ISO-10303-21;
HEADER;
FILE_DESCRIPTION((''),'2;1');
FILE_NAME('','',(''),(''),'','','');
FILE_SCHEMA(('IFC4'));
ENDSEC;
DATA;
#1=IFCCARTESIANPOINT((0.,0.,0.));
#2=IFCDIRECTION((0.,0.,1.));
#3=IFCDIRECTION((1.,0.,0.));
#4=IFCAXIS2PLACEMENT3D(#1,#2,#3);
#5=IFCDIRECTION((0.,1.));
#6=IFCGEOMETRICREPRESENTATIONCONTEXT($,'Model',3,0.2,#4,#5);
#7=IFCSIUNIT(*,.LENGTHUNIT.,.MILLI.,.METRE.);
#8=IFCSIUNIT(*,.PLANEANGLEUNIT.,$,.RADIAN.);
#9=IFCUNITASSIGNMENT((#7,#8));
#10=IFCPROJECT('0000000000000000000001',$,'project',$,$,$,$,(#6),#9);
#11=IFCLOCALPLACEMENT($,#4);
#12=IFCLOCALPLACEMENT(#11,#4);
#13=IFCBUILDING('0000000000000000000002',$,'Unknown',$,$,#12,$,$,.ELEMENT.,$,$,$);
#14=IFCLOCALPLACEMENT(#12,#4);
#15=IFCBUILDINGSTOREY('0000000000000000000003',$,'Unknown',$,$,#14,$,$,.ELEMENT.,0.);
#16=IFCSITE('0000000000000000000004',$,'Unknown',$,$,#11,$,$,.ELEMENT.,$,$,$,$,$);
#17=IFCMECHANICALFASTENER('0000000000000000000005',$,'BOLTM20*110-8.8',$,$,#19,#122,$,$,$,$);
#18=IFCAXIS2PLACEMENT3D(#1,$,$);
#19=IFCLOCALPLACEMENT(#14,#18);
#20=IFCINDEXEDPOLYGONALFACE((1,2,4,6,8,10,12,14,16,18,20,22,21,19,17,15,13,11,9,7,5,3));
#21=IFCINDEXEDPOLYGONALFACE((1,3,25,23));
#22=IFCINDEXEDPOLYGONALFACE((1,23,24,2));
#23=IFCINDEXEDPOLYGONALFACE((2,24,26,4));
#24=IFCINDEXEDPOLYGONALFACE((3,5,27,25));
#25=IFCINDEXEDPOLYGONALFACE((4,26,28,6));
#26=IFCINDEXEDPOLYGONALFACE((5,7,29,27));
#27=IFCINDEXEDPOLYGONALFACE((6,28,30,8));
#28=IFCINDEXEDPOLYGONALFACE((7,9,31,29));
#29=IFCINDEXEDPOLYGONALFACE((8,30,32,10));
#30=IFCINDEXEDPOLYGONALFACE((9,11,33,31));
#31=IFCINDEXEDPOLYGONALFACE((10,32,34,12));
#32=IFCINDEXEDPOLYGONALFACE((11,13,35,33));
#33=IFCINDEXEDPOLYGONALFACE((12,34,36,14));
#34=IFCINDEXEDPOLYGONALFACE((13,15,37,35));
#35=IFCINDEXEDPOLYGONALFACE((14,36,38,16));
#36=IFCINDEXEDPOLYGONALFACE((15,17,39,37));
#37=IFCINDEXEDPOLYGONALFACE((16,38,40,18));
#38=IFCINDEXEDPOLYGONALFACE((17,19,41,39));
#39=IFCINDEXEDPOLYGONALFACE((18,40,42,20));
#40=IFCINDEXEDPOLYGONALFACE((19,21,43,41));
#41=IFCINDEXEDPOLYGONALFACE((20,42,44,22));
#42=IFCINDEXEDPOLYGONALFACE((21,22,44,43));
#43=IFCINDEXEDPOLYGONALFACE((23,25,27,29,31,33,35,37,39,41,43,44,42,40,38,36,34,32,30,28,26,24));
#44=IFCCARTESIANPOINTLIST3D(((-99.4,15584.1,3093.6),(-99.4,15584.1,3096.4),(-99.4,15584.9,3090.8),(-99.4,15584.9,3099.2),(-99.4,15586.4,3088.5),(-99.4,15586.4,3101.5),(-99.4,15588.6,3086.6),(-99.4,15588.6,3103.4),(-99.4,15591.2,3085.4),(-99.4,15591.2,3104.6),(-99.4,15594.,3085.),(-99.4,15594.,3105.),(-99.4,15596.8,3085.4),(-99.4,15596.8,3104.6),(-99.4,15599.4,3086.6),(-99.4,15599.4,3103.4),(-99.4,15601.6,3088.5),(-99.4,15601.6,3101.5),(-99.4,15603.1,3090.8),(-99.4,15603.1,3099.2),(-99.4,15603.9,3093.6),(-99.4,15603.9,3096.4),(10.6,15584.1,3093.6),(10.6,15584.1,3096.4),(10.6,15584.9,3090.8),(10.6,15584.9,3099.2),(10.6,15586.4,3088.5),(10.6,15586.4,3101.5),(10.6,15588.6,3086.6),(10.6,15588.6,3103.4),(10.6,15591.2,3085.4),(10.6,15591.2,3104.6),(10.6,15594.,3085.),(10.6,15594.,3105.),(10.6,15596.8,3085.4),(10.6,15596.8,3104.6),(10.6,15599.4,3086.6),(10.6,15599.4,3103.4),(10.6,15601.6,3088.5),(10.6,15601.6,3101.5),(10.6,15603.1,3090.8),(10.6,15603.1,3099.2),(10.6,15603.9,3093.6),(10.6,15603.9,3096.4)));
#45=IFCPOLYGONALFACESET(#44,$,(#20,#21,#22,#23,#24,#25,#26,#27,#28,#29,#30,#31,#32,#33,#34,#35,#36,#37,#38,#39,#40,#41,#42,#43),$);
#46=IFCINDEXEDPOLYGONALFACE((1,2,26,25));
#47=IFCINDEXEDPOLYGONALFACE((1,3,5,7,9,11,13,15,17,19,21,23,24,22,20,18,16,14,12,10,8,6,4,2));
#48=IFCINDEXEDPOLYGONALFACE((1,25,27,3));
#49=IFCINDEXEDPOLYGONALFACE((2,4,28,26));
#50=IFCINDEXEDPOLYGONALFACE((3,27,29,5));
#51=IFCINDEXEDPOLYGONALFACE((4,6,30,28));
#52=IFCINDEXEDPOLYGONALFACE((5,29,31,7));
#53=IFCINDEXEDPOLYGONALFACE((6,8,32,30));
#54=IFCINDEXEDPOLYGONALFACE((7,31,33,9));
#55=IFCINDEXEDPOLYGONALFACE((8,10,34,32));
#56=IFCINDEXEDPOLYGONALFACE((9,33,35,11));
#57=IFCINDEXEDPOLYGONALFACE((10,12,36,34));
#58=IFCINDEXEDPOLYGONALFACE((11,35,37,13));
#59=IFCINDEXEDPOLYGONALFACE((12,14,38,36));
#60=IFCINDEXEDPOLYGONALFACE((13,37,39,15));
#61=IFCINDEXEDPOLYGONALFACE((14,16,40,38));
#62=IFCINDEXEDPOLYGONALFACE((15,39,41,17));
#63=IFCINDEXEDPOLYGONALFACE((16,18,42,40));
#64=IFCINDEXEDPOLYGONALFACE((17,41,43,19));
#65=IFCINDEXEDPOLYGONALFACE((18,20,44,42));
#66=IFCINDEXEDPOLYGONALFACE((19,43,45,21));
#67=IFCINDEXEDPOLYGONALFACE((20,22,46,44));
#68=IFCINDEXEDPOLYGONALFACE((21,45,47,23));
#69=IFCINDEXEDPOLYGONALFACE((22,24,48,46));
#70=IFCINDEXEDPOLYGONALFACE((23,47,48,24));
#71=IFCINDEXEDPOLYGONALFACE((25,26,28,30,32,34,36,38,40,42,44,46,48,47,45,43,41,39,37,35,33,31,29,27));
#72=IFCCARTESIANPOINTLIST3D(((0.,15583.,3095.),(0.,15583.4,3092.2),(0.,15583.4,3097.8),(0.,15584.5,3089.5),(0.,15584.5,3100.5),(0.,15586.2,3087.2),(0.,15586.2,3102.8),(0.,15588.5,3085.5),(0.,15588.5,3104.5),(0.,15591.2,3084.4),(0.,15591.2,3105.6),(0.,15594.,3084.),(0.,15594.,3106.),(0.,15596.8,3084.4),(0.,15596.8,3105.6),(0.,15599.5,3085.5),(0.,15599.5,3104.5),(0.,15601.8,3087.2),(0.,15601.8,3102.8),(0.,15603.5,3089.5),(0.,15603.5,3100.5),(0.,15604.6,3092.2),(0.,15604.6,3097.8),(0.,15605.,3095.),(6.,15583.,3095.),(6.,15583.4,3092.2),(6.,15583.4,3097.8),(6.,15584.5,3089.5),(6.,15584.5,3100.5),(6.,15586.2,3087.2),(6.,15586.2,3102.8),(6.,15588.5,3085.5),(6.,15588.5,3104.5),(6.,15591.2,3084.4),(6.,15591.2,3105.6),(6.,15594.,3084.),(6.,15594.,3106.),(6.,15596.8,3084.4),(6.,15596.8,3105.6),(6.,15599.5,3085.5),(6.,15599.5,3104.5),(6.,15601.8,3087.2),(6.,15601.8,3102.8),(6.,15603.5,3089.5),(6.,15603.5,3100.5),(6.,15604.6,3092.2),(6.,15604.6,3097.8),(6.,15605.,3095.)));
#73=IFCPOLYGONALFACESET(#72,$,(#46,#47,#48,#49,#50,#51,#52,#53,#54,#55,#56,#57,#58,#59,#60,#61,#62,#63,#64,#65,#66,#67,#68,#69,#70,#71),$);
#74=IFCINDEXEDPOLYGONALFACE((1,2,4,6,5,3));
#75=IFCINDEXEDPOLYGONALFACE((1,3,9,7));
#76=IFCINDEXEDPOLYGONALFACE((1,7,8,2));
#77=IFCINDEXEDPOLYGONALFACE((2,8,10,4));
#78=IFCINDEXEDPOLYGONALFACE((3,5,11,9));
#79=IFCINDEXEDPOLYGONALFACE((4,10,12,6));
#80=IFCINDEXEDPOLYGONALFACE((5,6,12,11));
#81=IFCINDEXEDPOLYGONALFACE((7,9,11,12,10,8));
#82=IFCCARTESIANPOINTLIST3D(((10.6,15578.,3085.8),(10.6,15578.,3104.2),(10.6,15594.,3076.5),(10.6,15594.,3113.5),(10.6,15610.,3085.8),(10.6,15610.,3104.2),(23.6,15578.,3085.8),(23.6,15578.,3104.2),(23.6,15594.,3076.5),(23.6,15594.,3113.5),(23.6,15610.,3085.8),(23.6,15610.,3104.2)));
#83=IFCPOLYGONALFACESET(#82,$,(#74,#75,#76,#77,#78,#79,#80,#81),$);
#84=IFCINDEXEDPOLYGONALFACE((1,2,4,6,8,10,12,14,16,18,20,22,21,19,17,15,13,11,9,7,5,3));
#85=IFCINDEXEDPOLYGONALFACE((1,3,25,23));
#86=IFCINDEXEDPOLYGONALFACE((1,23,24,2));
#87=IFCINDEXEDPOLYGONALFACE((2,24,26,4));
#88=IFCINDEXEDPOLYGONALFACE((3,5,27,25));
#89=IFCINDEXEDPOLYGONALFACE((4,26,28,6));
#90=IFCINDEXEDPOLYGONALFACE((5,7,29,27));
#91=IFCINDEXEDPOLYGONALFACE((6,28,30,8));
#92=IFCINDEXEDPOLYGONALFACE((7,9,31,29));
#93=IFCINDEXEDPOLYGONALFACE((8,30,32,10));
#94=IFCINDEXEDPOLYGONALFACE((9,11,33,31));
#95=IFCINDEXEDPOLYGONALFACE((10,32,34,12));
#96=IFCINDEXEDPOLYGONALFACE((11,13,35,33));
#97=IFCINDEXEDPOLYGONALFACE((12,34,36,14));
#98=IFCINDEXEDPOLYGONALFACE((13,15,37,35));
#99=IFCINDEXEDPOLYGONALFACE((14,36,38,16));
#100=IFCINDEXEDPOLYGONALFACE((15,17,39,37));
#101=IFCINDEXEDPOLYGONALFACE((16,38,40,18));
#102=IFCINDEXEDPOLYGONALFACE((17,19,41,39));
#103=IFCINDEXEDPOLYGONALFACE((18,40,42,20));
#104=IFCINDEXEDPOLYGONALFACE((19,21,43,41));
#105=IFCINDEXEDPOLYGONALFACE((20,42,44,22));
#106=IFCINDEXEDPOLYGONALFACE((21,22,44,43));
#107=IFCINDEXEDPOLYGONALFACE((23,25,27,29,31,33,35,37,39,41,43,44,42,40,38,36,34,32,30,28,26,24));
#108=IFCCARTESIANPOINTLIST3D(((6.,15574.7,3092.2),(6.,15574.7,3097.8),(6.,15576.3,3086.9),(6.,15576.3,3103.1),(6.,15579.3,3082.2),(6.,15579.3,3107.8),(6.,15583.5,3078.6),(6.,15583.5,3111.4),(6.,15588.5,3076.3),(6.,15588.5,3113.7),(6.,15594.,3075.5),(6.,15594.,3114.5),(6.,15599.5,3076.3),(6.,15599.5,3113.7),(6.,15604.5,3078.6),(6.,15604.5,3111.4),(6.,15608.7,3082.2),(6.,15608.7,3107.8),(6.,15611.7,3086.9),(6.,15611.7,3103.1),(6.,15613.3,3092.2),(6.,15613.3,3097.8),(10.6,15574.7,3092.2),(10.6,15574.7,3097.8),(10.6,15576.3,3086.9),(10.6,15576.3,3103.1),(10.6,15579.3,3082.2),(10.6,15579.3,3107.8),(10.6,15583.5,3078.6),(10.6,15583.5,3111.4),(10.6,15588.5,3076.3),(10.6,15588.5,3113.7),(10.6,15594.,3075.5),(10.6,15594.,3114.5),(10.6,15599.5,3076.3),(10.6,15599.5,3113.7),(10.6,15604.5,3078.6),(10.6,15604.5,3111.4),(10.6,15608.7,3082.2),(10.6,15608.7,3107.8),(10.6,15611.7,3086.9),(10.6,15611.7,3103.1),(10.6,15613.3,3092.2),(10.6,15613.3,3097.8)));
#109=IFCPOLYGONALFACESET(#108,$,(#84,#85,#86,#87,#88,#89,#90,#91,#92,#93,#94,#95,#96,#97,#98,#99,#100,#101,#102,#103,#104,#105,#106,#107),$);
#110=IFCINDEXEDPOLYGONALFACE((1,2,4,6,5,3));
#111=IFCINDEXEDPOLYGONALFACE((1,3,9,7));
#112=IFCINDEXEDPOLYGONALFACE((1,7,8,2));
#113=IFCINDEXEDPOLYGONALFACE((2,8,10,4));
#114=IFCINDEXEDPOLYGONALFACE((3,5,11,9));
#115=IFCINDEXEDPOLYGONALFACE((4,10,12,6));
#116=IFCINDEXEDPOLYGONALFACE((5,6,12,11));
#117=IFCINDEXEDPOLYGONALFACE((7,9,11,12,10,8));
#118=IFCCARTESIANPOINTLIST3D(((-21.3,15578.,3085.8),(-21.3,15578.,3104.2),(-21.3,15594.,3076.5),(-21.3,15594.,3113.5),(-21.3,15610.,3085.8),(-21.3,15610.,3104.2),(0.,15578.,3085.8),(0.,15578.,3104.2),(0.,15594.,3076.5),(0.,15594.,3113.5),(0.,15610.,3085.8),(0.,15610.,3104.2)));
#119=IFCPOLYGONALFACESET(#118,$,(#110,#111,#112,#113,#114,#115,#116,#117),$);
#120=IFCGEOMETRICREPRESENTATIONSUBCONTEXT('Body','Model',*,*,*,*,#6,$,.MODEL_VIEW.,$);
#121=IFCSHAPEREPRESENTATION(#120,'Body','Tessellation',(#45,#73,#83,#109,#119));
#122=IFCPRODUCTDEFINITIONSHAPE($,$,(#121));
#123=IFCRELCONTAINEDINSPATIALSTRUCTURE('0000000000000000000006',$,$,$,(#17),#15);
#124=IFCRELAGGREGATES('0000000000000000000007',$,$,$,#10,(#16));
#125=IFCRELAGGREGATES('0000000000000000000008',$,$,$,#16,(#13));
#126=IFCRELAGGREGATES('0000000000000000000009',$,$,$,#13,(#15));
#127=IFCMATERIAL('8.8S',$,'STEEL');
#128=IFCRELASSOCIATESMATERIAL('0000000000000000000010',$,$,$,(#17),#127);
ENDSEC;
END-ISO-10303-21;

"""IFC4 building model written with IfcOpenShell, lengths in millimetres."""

from ifc_helpers import new_model, si_unit, direction, frame, origin_with_axes, place, context, subcontext, project, spatial, line, arc, indexed_curve, outline, extrude, source, transform, mapped, material, element, save


model = new_model("IFC4")

# Units and contexts
model_context = context("Model", 3, precision=0.2, world=origin_with_axes(), true_north=direction((0.0, 1.0)))
body_context = subcontext(model_context, "Body", "Model", "MODEL_VIEW")
ifc_project = project(units=[si_unit("LENGTHUNIT", "METRE", prefix="MILLI"), si_unit("PLANEANGLEUNIT", "RADIAN")], contexts=[model_context])

# Site, building, storey
site_placement = place(None, origin_with_axes())
site = spatial("IfcSite", under=ifc_project, at=site_placement, Name="Unknown", CompositionType="ELEMENT")
building_placement = place(site_placement, origin_with_axes())
building = spatial("IfcBuilding", under=site, at=building_placement, Name="Unknown", CompositionType="ELEMENT")
storey_placement = place(building_placement, origin_with_axes())
storey = spatial("IfcBuildingStorey", under=building, at=storey_placement, Name="Unknown", CompositionType="ELEMENT", Elevation=0.0)

# Mechanical fastener
ifc_material_1 = material(Name="8.8S", Category="STEEL")
shared_shape_1 = source(origin_with_axes(), body_context, "Body", "SweptSolid", [
    extrude(outline(indexed_curve([(10.0, 0.0), (0.0, 10.0), (-10.0, 0.0), (0.0, -10.0)], segments=[arc(1, 2, 3), arc(3, 4, 1)])), frame((0.0, 0.0, 4.6), z_axis=(0.0, 0.0, -1.0), x_axis=(0.0, 1.0, 0.0)), (0.0, 0.0, 1.0), 110.0),
    extrude(outline(indexed_curve([(0.0, 11.0), (7.8, 7.8), (11.0, 0.0), (7.8, -7.8), (0.0, -11.0), (-1.0, -11.0), (-11.0, 0.0), (-7.8, 7.8)], segments=[arc(1, 2, 3), arc(3, 4, 5), arc(5, 6, 7), arc(7, 8, 1)])), frame((0.0, 0.0, 0.0), z_axis=(0.0, 0.0, -1.0), x_axis=(0.0, 1.0, 0.0)), (0.0, 0.0, 1.0), 6.0),
    extrude(outline(indexed_curve([(18.5, 0.0), (9.2, 16.0), (-9.2, 16.0), (-18.5, 0.0), (-9.2, -16.0), (9.2, -16.0)], segments=[line(1, 2, 3, 4, 5, 6, 1)])), frame((0.0, 0.0, 17.6), z_axis=(0.0, 0.0, -1.0), x_axis=(0.0, 1.0, 0.0)), (0.0, 0.0, 1.0), 13.0),
    extrude(outline(indexed_curve([(19.5, 0.0), (0.0, 19.5), (-19.5, 0.0), (0.0, -19.5)], segments=[arc(1, 2, 3), arc(3, 4, 1)])), frame((0.0, 0.0, 4.6), z_axis=(0.0, 0.0, -1.0), x_axis=(0.0, 1.0, 0.0)), (0.0, 0.0, 1.0), 4.6),
    extrude(outline(indexed_curve([(18.5, 0.0), (9.2, 16.0), (-9.2, 16.0), (-18.5, 0.0), (-9.2, -16.0), (9.2, -16.0)], segments=[line(1, 2, 3, 4, 5, 6, 1)])), frame((0.0, 0.0, -6.0), z_axis=(0.0, 0.0, -1.0), x_axis=(0.0, 1.0, 0.0)), (0.0, 0.0, 1.0), 21.3),
])
mechanical_fastener_1_placement = place(storey_placement, frame((6.0, 15594.0, 3095.0), z_axis=(1.0, 0.0, 0.0), x_axis=(0.0, 1.0, 0.0)))
element("IfcMechanicalFastener", 1, at=mechanical_fastener_1_placement, inside=storey, material=ifc_material_1, Name="BOLTM20*110-8.8", context=body_context, shape_type="MappedRepresentation", body=[
    mapped(shared_shape_1, transform((0.0, 0.0, 0.0))),
])

save(model, "model.ifc")
